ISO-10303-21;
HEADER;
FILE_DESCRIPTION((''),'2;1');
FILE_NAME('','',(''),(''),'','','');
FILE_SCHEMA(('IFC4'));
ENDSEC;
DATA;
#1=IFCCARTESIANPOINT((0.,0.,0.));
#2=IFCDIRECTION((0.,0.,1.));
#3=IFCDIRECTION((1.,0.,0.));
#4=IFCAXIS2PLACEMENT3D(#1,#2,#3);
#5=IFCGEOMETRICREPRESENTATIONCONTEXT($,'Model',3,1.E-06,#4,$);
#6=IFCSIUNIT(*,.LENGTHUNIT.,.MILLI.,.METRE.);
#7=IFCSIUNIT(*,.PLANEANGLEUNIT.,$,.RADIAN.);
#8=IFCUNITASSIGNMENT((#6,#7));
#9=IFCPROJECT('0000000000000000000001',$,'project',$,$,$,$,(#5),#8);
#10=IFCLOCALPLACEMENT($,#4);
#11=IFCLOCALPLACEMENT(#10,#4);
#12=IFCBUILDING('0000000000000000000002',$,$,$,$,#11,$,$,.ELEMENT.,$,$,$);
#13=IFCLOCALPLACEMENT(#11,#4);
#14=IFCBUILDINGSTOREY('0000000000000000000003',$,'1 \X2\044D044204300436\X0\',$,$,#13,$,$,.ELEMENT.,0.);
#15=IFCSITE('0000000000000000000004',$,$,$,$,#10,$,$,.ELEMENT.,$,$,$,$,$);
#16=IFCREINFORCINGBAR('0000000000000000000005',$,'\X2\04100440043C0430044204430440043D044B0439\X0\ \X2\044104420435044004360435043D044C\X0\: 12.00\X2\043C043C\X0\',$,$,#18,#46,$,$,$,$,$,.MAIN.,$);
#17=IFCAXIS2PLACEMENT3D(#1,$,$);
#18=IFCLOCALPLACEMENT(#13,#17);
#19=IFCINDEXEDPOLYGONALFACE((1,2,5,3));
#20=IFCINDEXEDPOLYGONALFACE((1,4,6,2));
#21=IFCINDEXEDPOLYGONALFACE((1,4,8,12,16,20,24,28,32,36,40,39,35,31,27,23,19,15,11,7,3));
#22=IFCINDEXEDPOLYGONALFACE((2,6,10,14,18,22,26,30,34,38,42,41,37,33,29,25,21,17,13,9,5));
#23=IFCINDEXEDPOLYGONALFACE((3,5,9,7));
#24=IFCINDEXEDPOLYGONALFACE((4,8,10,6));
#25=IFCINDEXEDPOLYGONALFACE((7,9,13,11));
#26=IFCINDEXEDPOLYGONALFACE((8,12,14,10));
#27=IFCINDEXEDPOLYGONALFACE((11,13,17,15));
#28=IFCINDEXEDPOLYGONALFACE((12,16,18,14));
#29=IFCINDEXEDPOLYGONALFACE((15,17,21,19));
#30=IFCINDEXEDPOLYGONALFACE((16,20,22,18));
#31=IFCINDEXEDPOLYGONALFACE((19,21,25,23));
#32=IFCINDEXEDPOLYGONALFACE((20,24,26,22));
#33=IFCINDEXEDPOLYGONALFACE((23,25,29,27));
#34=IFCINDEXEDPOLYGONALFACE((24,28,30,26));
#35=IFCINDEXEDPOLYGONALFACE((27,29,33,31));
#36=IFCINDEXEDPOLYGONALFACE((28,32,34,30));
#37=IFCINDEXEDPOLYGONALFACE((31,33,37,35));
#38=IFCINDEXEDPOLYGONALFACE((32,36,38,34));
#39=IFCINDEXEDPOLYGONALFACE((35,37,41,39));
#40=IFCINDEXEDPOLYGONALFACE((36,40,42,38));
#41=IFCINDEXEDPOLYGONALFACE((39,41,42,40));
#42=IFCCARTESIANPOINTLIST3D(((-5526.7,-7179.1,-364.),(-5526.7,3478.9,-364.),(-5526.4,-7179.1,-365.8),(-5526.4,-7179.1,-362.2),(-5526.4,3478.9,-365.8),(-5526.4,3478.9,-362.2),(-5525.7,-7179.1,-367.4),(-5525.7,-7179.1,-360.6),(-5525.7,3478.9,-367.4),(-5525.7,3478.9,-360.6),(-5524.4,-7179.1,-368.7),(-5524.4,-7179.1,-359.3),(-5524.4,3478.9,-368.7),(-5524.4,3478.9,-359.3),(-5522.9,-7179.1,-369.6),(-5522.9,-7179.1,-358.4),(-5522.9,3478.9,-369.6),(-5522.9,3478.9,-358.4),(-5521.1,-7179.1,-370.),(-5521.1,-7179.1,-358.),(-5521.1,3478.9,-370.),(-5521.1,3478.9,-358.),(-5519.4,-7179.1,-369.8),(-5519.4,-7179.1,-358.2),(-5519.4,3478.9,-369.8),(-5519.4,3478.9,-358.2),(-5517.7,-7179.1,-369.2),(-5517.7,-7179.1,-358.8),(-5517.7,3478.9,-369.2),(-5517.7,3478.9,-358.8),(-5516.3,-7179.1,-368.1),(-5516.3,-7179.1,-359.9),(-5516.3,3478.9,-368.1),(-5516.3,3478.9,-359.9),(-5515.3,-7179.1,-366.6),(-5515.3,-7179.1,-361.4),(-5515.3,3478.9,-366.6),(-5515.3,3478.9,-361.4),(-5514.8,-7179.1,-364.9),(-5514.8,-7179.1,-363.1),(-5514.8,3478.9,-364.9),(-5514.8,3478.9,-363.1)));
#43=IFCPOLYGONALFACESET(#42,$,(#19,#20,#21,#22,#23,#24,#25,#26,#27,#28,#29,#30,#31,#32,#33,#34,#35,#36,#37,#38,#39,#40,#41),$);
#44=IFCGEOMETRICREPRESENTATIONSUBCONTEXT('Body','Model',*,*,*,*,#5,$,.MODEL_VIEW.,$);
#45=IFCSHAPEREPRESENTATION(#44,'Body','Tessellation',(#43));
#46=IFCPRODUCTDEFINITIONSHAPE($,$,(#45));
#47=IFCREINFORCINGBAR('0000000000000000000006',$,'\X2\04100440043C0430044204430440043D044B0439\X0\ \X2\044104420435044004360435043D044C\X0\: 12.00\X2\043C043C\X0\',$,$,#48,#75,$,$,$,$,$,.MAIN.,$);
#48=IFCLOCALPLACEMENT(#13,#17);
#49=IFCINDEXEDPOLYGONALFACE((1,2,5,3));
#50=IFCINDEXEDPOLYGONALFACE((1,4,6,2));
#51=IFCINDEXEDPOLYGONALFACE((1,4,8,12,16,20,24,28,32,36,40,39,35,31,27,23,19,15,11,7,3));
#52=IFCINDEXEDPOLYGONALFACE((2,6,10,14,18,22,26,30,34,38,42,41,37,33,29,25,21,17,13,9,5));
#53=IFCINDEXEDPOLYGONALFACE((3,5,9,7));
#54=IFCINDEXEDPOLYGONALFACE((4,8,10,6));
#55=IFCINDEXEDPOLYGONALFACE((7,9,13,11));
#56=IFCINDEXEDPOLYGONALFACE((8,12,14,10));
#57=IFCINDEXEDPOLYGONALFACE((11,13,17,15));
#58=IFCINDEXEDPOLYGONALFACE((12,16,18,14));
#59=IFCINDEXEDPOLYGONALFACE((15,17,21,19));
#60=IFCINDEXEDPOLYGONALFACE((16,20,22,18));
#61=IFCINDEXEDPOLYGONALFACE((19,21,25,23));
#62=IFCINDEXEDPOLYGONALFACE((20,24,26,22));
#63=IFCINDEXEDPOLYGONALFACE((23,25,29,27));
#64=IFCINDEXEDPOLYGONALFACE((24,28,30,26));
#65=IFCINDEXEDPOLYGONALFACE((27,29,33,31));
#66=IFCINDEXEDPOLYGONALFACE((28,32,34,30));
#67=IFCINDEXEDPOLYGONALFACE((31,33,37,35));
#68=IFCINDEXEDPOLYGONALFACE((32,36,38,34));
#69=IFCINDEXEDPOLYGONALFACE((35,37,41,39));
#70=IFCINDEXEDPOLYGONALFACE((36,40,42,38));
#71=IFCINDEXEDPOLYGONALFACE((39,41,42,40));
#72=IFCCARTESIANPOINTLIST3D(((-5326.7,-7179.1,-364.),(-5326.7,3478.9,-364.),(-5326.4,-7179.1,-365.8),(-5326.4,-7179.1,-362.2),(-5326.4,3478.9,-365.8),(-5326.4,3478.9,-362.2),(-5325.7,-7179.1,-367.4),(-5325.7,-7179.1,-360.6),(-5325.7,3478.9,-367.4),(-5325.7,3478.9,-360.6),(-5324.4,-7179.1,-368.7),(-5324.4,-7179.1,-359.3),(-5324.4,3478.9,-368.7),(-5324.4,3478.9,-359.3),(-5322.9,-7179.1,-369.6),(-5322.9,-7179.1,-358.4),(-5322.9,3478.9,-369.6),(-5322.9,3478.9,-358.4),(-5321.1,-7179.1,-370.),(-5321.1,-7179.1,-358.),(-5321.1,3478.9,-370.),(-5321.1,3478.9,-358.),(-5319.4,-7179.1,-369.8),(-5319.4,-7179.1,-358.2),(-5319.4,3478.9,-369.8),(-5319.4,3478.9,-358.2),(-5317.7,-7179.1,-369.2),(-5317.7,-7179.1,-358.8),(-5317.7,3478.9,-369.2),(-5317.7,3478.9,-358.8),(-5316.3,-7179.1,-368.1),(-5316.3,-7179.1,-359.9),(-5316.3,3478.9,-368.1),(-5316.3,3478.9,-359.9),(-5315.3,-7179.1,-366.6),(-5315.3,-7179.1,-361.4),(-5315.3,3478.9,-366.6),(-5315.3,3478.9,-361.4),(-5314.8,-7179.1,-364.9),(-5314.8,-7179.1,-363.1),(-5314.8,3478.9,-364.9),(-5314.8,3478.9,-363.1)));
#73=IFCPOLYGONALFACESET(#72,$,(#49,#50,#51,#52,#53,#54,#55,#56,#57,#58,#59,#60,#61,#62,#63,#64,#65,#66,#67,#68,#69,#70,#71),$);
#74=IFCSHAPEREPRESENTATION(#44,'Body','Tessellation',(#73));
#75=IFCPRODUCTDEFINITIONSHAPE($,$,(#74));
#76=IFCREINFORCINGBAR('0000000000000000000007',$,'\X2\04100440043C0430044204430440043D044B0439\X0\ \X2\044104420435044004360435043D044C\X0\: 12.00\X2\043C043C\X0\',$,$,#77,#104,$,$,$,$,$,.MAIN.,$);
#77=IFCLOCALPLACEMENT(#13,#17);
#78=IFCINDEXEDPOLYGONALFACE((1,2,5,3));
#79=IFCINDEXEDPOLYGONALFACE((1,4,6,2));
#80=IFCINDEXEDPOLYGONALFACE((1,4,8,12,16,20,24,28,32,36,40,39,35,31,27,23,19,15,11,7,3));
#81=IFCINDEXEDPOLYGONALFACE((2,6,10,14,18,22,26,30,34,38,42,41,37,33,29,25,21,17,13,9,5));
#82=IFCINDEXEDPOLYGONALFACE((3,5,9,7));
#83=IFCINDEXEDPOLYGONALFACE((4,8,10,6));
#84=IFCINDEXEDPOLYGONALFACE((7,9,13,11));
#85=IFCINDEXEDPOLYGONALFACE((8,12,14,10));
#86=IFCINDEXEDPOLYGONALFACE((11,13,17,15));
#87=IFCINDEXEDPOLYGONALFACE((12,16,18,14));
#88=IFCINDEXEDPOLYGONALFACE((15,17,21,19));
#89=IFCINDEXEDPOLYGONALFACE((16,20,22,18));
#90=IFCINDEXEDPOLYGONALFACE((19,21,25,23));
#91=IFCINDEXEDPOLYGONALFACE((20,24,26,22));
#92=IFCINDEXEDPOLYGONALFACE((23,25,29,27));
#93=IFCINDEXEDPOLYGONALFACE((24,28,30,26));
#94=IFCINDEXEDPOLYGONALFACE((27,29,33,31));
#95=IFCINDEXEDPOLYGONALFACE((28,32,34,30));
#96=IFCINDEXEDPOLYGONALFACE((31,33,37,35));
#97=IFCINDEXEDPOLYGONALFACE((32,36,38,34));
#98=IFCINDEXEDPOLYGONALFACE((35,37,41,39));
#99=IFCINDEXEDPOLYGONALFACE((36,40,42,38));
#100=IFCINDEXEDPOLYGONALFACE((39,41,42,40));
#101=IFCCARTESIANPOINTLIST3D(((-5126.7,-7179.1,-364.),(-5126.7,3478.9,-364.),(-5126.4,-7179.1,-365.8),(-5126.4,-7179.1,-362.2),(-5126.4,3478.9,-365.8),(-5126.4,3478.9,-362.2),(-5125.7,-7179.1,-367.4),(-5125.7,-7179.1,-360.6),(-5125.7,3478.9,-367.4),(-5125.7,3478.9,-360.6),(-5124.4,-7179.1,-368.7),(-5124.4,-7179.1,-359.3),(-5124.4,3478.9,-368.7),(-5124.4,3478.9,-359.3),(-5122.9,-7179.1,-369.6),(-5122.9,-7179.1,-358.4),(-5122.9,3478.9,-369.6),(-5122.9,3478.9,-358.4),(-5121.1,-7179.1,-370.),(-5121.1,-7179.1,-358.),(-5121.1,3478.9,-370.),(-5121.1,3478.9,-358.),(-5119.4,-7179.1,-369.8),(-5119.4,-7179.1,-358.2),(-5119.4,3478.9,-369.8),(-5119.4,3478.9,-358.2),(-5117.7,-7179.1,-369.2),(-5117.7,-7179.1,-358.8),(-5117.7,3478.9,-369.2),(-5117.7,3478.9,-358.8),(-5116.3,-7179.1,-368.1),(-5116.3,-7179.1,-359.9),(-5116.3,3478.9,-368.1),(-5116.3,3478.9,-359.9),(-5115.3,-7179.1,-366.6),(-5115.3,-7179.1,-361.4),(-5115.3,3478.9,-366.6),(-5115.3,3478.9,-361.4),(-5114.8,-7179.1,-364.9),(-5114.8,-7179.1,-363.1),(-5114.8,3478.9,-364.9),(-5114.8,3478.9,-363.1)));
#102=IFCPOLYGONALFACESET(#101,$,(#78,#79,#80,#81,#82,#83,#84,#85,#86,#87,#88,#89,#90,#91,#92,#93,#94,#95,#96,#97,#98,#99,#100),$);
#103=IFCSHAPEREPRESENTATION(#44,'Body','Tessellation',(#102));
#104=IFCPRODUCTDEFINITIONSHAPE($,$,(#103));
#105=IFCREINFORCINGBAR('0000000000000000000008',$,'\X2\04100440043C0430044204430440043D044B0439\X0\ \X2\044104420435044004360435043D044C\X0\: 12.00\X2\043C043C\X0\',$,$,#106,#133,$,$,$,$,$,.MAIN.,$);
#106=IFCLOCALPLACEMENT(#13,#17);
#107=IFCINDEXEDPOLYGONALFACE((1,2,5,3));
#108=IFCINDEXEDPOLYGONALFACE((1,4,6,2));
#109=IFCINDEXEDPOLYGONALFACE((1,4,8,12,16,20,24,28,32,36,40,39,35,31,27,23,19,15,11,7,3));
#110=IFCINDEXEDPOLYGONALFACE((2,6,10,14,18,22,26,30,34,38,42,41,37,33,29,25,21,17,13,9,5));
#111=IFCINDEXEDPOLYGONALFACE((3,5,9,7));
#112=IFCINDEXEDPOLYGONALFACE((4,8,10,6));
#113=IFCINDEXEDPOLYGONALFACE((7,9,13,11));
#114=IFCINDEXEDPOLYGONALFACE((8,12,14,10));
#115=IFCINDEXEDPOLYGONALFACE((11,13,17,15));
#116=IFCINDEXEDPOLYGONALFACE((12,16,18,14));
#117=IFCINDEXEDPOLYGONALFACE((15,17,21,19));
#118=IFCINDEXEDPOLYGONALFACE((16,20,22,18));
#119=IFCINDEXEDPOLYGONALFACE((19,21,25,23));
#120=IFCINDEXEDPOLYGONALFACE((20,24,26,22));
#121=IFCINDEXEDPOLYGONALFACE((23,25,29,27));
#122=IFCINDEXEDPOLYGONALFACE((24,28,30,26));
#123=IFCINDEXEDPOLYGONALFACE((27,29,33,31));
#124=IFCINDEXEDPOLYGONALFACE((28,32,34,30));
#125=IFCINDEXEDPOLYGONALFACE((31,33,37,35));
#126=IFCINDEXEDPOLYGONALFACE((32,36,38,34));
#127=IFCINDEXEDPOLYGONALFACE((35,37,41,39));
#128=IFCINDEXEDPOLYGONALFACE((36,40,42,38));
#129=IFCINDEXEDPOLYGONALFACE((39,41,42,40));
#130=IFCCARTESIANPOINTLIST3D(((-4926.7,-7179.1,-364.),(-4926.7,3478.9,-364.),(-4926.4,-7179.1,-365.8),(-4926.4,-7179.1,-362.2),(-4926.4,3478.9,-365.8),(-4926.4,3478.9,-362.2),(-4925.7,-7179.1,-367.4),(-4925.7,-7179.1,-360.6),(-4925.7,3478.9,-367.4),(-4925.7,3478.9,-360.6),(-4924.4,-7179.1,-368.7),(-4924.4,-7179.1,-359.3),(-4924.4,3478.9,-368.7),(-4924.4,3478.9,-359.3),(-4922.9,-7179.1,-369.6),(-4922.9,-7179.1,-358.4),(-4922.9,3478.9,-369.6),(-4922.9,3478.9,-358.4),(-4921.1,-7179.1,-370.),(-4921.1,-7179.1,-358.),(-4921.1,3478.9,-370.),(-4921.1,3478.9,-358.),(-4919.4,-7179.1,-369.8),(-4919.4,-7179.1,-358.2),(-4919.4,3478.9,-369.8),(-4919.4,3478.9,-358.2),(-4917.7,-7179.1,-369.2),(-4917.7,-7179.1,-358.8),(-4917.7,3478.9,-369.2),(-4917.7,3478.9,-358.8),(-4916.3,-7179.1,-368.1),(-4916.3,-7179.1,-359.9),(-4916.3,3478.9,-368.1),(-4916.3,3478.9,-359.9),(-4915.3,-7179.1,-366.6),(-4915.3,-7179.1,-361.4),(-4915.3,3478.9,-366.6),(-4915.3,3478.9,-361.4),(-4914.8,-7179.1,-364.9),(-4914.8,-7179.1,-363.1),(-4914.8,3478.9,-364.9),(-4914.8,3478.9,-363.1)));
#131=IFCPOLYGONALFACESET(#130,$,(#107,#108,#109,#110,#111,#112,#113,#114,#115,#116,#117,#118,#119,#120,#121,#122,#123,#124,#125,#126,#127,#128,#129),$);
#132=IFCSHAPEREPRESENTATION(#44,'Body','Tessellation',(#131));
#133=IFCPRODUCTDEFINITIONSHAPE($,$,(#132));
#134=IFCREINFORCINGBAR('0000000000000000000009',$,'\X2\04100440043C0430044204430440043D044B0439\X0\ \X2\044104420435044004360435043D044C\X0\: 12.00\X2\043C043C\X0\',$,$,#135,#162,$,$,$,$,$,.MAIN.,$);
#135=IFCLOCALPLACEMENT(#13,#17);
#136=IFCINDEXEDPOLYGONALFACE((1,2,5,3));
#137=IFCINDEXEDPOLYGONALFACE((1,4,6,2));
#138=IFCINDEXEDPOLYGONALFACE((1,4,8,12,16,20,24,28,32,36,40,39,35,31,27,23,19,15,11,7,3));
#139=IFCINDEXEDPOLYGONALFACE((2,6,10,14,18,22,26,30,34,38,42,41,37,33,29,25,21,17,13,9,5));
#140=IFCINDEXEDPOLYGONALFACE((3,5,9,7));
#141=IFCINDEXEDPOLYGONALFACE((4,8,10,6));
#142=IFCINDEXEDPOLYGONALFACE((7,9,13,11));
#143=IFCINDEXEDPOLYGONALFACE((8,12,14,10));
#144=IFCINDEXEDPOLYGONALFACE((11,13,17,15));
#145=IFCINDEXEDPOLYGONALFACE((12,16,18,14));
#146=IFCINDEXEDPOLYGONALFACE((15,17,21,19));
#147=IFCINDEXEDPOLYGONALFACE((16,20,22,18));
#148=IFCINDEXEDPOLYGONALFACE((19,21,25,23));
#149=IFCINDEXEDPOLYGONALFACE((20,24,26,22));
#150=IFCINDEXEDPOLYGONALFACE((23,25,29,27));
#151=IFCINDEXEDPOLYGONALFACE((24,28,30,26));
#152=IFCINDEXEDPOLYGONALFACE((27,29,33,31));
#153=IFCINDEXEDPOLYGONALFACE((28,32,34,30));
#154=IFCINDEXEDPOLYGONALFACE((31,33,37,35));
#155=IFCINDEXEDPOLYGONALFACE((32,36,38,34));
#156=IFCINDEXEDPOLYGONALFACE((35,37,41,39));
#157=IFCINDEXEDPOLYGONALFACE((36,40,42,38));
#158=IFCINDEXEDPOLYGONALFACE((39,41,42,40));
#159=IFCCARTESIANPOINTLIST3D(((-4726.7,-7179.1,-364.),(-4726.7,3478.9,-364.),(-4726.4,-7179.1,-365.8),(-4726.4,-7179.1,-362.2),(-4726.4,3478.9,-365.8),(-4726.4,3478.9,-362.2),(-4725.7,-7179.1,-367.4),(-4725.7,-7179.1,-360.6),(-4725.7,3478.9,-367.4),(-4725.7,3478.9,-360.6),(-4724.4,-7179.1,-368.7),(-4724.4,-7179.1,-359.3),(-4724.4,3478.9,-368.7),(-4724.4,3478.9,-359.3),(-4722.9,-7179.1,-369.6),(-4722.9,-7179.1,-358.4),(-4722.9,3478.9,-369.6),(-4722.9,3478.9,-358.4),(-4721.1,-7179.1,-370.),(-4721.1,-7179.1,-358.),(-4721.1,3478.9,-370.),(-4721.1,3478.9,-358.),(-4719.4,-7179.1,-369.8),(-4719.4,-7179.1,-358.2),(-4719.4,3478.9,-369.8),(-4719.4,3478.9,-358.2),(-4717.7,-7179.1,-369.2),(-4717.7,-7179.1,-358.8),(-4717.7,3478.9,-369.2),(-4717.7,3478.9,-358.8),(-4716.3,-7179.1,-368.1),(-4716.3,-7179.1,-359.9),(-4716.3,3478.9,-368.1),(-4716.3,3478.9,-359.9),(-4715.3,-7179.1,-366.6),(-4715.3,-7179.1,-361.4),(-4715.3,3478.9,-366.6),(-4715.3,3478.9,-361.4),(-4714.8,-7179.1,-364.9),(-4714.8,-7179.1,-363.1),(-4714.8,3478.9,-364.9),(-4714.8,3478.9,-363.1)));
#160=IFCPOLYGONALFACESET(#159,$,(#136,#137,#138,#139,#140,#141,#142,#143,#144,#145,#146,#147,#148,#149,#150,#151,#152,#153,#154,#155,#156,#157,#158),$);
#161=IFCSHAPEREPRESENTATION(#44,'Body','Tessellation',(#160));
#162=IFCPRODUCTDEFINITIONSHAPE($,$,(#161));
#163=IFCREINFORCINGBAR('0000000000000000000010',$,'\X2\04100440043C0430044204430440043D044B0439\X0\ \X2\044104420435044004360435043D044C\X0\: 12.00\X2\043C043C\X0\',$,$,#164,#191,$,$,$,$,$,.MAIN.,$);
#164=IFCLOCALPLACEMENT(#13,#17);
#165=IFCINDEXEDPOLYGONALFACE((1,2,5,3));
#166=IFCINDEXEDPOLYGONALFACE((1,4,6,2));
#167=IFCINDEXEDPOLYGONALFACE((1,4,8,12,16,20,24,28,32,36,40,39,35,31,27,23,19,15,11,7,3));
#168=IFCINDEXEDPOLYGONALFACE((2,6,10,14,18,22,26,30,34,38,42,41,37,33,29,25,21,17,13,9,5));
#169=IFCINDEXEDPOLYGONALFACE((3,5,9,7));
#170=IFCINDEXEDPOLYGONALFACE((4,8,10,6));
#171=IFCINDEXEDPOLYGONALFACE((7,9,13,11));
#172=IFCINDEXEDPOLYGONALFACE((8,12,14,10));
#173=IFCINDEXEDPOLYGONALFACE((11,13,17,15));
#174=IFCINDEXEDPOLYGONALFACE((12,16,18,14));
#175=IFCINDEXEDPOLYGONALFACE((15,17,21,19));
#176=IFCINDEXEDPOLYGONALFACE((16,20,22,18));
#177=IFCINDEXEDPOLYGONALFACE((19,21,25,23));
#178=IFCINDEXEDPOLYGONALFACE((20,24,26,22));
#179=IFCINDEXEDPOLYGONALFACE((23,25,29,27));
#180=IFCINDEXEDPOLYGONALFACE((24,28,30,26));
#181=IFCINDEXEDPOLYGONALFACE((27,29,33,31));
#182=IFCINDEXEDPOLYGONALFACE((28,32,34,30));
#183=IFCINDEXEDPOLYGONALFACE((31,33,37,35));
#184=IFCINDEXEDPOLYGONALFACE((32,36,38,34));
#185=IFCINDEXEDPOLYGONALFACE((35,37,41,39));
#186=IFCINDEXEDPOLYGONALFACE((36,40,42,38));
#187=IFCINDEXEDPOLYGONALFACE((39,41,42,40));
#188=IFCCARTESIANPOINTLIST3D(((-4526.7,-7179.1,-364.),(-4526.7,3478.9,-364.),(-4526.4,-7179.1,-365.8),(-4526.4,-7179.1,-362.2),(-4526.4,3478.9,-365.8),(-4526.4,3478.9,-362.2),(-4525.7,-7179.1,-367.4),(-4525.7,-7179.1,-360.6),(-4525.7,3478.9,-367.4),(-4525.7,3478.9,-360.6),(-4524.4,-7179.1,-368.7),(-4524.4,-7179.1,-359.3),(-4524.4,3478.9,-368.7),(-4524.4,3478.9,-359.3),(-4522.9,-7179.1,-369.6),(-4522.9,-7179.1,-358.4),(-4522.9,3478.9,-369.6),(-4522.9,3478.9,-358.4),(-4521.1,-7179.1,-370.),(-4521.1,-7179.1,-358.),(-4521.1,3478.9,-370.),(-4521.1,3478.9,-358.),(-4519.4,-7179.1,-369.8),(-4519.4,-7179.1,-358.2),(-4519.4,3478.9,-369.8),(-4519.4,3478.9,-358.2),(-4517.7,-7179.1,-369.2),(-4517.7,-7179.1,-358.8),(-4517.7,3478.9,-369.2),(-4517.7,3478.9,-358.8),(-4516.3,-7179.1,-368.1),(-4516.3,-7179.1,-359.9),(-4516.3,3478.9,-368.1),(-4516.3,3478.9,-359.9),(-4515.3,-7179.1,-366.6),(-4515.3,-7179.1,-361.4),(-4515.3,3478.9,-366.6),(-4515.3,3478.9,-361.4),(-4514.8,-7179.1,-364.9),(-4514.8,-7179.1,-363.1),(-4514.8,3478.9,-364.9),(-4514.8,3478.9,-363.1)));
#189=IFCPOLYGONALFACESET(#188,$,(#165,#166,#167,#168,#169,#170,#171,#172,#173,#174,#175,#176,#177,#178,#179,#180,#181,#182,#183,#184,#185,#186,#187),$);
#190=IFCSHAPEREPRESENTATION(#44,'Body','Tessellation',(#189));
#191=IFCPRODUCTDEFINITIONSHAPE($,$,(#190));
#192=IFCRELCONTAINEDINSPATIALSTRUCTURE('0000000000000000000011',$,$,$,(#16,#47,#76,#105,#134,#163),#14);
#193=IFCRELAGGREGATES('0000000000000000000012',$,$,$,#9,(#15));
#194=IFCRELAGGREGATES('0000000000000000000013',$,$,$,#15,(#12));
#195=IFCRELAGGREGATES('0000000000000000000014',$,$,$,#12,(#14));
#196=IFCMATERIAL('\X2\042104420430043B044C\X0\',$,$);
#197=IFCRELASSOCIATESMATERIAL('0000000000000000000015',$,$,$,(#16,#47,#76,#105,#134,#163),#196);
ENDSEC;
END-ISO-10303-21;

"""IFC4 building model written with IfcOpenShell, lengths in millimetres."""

from ifc_helpers import new_model, entity, si_unit, origin_with_axes, place, context, subcontext, project, spatial, source, transform, mapped, material, element, save


model = new_model("IFC4")

# Units and contexts
model_context = context("Model", 3, precision=1e-06, world=origin_with_axes())
body_context = subcontext(model_context, "Body", "Model", "MODEL_VIEW")
ifc_project = project(units=[si_unit("LENGTHUNIT", "METRE", prefix="MILLI"), si_unit("PLANEANGLEUNIT", "RADIAN")], contexts=[model_context])

# Site, building, storey
site_placement = place(None, origin_with_axes())
site = spatial("IfcSite", under=ifc_project, at=site_placement, CompositionType="ELEMENT")
building_placement = place(site_placement, origin_with_axes())
building = spatial("IfcBuilding", under=site, at=building_placement, CompositionType="ELEMENT")
storey_placement = place(building_placement, origin_with_axes())
storey = spatial("IfcBuildingStorey", under=building, at=storey_placement, Name="1 этаж", CompositionType="ELEMENT", Elevation=0.0)

# Reinforcing bars
ifc_material = material(Name="Сталь")
shared_shape_1 = source(origin_with_axes(), body_context, "Body", "AdvancedSweptSolid", [
    entity("IfcSweptDiskSolid", entity("IfcIndexedPolyCurve", entity("IfcCartesianPointList3D", [[0.0, 0.0, 0.0], [10658.0, 0.0, 0.0]]), [entity("IfcLineIndex", [1, 2])]), 6.0),
])
reinforcing_bar_1_placement = place(storey_placement, origin_with_axes())
element("IfcReinforcingBar", 1, at=reinforcing_bar_1_placement, inside=storey, material=ifc_material, Name="Арматурный стержень: 12.00мм", PredefinedType="MAIN", context=body_context, shape_type="MappedRepresentation", body=[
    mapped(shared_shape_1, transform((-5520.7, -7179.1, -364.0), x_axis=(0.0, 1.0, 0.0), y_axis=(-1.0, 0.0, 0.0), z_axis=(0.0, 0.0, 1.0), scale=1.0)),
])
reinforcing_bar_2_placement = place(storey_placement, origin_with_axes())
element("IfcReinforcingBar", 2, at=reinforcing_bar_2_placement, inside=storey, material=ifc_material, Name="Арматурный стержень: 12.00мм", PredefinedType="MAIN", context=body_context, shape_type="MappedRepresentation", body=[
    mapped(shared_shape_1, transform((-5320.7, -7179.1, -364.0), x_axis=(0.0, 1.0, 0.0), y_axis=(-1.0, 0.0, 0.0), z_axis=(0.0, 0.0, 1.0), scale=1.0)),
])
reinforcing_bar_3_placement = place(storey_placement, origin_with_axes())
element("IfcReinforcingBar", 3, at=reinforcing_bar_3_placement, inside=storey, material=ifc_material, Name="Арматурный стержень: 12.00мм", PredefinedType="MAIN", context=body_context, shape_type="MappedRepresentation", body=[
    mapped(shared_shape_1, transform((-5120.7, -7179.1, -364.0), x_axis=(0.0, 1.0, 0.0), y_axis=(-1.0, 0.0, 0.0), z_axis=(0.0, 0.0, 1.0), scale=1.0)),
])
reinforcing_bar_4_placement = place(storey_placement, origin_with_axes())
element("IfcReinforcingBar", 4, at=reinforcing_bar_4_placement, inside=storey, material=ifc_material, Name="Арматурный стержень: 12.00мм", PredefinedType="MAIN", context=body_context, shape_type="MappedRepresentation", body=[
    mapped(shared_shape_1, transform((-4920.7, -7179.1, -364.0), x_axis=(0.0, 1.0, 0.0), y_axis=(-1.0, 0.0, 0.0), z_axis=(0.0, 0.0, 1.0), scale=1.0)),
])
reinforcing_bar_5_placement = place(storey_placement, origin_with_axes())
element("IfcReinforcingBar", 5, at=reinforcing_bar_5_placement, inside=storey, material=ifc_material, Name="Арматурный стержень: 12.00мм", PredefinedType="MAIN", context=body_context, shape_type="MappedRepresentation", body=[
    mapped(shared_shape_1, transform((-4720.7, -7179.1, -364.0), x_axis=(0.0, 1.0, 0.0), y_axis=(-1.0, 0.0, 0.0), z_axis=(0.0, 0.0, 1.0), scale=1.0)),
])
reinforcing_bar_6_placement = place(storey_placement, origin_with_axes())
element("IfcReinforcingBar", 6, at=reinforcing_bar_6_placement, inside=storey, material=ifc_material, Name="Арматурный стержень: 12.00мм", PredefinedType="MAIN", context=body_context, shape_type="MappedRepresentation", body=[
    mapped(shared_shape_1, transform((-4520.7, -7179.1, -364.0), x_axis=(0.0, 1.0, 0.0), y_axis=(-1.0, 0.0, 0.0), z_axis=(0.0, 0.0, 1.0), scale=1.0)),
])

save(model, "model.ifc")
